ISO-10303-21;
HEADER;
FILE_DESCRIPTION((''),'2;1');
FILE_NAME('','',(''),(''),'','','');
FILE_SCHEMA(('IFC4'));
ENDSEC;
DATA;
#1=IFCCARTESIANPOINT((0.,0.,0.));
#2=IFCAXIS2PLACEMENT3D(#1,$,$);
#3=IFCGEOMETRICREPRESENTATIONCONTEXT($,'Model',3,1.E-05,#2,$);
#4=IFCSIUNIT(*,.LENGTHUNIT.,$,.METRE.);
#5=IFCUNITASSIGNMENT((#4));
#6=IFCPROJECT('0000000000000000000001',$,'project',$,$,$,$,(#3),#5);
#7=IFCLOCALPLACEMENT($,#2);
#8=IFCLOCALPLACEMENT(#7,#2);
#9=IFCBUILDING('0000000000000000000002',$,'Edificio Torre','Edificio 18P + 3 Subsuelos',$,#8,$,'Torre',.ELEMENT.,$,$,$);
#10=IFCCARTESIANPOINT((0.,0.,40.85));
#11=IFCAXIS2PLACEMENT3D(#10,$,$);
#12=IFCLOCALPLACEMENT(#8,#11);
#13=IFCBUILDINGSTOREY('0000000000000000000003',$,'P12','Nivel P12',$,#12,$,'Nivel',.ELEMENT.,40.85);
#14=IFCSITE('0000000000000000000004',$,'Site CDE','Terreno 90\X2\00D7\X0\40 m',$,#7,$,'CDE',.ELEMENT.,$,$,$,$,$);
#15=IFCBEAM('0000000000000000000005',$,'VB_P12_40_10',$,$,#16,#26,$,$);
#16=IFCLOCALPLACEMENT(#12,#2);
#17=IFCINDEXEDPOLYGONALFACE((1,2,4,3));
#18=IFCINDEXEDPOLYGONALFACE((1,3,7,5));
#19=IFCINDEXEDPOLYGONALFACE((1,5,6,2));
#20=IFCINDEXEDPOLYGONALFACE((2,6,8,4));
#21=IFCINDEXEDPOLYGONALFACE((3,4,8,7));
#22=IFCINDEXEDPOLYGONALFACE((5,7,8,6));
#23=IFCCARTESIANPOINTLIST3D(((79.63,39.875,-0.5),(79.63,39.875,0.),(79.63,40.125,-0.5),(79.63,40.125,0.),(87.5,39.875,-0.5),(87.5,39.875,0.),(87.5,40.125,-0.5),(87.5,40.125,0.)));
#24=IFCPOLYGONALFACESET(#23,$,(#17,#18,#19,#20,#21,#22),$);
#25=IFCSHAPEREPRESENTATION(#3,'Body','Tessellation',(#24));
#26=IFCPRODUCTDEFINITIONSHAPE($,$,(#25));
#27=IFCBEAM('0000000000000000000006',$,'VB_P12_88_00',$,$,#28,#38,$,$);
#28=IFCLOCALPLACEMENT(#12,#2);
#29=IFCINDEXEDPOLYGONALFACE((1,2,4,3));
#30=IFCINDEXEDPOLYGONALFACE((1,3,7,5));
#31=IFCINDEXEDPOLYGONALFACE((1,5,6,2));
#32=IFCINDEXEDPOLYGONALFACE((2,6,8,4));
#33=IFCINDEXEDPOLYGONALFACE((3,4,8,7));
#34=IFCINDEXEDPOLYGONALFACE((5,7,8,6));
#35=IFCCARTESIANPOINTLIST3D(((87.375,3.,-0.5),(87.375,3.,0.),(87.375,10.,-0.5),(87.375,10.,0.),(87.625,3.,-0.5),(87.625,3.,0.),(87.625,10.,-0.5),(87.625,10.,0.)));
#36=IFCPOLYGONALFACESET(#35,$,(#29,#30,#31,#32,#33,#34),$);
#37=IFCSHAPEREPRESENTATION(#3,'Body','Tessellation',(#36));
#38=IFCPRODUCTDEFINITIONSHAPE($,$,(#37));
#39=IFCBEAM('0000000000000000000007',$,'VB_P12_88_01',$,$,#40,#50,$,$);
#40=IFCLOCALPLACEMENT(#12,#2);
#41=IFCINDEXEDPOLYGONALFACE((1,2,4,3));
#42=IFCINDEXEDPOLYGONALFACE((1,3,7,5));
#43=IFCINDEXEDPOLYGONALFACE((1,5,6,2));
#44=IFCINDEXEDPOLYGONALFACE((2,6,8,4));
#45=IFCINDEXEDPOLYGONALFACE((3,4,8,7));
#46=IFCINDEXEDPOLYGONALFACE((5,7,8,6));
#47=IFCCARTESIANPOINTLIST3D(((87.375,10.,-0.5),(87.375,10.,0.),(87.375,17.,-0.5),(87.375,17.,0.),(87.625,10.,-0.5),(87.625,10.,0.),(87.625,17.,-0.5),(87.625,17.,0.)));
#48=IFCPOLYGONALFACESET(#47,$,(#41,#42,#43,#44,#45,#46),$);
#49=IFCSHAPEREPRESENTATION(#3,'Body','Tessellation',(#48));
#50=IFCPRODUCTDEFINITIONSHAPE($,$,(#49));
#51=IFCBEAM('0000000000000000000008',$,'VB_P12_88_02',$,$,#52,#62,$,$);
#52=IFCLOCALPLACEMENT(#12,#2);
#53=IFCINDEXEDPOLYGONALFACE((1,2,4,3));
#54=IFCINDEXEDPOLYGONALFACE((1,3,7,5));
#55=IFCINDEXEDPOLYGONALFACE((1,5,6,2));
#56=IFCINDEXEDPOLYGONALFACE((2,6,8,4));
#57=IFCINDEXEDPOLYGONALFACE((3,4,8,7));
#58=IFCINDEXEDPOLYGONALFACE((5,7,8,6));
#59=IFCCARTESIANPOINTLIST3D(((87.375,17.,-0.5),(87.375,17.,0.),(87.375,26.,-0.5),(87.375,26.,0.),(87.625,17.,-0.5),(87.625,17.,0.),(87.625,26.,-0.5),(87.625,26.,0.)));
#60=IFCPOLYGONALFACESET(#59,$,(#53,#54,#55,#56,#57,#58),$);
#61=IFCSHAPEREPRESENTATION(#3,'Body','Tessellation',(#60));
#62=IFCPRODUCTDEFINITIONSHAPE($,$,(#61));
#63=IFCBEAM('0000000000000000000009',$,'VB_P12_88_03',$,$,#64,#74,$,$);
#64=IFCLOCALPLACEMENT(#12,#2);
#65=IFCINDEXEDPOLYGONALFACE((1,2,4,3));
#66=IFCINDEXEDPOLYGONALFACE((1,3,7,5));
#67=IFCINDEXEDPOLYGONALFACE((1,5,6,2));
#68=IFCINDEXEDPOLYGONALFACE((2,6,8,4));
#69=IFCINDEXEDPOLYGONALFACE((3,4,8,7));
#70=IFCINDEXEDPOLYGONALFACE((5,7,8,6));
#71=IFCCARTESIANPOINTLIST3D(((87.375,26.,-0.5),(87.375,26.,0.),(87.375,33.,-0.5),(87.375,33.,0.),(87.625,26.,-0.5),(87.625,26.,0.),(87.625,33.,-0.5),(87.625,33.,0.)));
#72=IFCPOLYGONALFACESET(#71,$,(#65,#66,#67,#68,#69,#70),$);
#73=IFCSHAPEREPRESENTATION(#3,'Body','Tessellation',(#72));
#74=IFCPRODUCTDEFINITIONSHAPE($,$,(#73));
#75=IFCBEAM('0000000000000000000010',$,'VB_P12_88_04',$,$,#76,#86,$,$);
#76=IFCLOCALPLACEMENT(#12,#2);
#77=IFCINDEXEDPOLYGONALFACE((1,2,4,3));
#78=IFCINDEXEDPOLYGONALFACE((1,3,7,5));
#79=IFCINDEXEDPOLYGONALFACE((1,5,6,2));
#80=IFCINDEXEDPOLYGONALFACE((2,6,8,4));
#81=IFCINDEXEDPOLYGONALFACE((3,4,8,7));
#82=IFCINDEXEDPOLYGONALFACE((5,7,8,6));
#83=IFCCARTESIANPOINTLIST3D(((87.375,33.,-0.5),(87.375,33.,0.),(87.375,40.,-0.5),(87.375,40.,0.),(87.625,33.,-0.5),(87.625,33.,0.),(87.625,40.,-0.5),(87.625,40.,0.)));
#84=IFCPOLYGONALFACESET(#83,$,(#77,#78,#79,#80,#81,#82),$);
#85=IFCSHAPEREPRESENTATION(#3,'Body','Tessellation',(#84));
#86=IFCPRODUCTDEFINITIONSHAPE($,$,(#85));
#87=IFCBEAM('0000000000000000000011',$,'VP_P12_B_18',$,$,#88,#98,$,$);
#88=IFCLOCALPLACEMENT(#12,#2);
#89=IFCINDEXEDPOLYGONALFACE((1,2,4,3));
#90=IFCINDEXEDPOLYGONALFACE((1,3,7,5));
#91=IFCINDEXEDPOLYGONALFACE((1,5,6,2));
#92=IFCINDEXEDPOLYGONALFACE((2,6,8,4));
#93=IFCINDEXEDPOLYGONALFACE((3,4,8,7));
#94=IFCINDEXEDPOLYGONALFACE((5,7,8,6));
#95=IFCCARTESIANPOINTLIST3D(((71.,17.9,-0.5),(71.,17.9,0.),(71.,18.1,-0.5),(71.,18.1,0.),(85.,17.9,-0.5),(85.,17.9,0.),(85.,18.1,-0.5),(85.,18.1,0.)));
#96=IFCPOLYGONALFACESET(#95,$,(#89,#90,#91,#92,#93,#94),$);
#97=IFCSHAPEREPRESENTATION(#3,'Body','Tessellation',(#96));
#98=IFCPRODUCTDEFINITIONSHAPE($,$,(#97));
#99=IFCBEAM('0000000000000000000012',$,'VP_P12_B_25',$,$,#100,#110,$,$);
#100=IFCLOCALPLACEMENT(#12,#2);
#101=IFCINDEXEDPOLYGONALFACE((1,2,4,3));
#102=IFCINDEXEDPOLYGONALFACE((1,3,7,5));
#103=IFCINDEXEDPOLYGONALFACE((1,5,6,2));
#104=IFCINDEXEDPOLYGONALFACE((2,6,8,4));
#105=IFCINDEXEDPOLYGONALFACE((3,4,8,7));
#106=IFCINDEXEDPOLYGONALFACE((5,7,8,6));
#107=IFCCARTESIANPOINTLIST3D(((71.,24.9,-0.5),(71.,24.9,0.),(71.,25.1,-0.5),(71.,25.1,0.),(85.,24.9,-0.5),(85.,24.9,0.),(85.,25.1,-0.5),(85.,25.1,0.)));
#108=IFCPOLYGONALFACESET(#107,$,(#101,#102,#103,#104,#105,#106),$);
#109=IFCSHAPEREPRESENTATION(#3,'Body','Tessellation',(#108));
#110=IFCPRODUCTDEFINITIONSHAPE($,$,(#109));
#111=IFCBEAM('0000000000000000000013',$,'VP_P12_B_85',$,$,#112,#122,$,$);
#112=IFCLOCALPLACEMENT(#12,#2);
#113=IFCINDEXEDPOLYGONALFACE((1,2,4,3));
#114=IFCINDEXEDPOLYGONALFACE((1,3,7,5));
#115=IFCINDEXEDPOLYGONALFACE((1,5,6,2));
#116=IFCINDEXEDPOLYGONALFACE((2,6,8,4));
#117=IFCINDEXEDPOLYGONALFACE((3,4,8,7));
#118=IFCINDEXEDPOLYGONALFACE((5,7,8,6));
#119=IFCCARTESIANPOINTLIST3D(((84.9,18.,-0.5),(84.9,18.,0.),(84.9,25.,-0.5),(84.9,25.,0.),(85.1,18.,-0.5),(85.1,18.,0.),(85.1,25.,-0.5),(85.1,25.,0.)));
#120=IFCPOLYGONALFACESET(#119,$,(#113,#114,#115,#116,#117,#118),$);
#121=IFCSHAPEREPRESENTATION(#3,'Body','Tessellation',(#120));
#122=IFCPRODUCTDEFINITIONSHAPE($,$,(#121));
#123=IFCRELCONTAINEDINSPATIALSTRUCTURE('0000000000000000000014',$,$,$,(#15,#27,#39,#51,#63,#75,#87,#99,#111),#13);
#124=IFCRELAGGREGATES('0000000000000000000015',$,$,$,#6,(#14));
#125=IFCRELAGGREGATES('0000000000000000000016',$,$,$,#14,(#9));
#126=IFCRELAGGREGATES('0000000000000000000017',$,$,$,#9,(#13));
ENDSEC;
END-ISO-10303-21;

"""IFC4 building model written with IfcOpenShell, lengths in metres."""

from ifc_helpers import new_model, si_unit, frame, origin, origin_2d, place, context, project, spatial, rectangle, extrude, element, save


model = new_model("IFC4")

# Units and contexts
model_context = context("Model", 3, precision=1e-05, world=origin())
ifc_project = project(units=[si_unit("LENGTHUNIT", "METRE")], contexts=[model_context])

# Site, building, storey
site_placement = place(None, origin())
site = spatial("IfcSite", under=ifc_project, at=site_placement, Name="Site CDE", Description="Terreno 90×40 m", LongName="CDE", CompositionType="ELEMENT")
building_placement = place(site_placement, origin())
building = spatial("IfcBuilding", under=site, at=building_placement, Name="Edificio Torre", Description="Edificio 18P + 3 Subsuelos", LongName="Torre", CompositionType="ELEMENT")
storey_placement = place(building_placement, frame((0.0, 0.0, 40.85)))
storey = spatial("IfcBuildingStorey", under=building, at=storey_placement, Name="P12", Description="Nivel P12", LongName="Nivel", CompositionType="ELEMENT", Elevation=40.85)

# Beams
beam_1_placement = place(storey_placement, frame((83.565, 40.0, -0.5)))
element("IfcBeam", 1, at=beam_1_placement, inside=storey, Name="VB_P12_40_10", context=model_context, shape_type="SweptSolid", body=[
    extrude(rectangle(XDim=7.87, YDim=0.25, at=origin_2d()), origin(), (0.0, 0.0, 1.0), 0.5),
])
for number, where, name in (
    (2, (87.5, 6.5, -0.5), "VB_P12_88_00"),
    (3, (87.5, 13.5, -0.5), "VB_P12_88_01"),
):
    element("IfcBeam", number, at=place(storey_placement, frame(where)), inside=storey, Name=name, context=model_context, shape_type="SweptSolid", body=[
        extrude(rectangle(XDim=0.25, YDim=7.0, at=origin_2d()), origin(), (0.0, 0.0, 1.0), 0.5),
    ])
beam_2_placement = place(storey_placement, frame((87.5, 21.5, -0.5)))
element("IfcBeam", 4, at=beam_2_placement, inside=storey, Name="VB_P12_88_02", context=model_context, shape_type="SweptSolid", body=[
    extrude(rectangle(XDim=0.25, YDim=9.0, at=origin_2d()), origin(), (0.0, 0.0, 1.0), 0.5),
])
for number, where, name in (
    (5, (87.5, 29.5, -0.5), "VB_P12_88_03"),
    (6, (87.5, 36.5, -0.5), "VB_P12_88_04"),
):
    element("IfcBeam", number, at=place(storey_placement, frame(where)), inside=storey, Name=name, context=model_context, shape_type="SweptSolid", body=[
        extrude(rectangle(XDim=0.25, YDim=7.0, at=origin_2d()), origin(), (0.0, 0.0, 1.0), 0.5),
    ])
for number, where, name in (
    (7, (78.0, 18.0, -0.5), "VP_P12_B_18"),
    (8, (78.0, 25.0, -0.5), "VP_P12_B_25"),
):
    element("IfcBeam", number, at=place(storey_placement, frame(where)), inside=storey, Name=name, context=model_context, shape_type="SweptSolid", body=[
        extrude(rectangle(XDim=14.0, YDim=0.2, at=origin_2d()), origin(), (0.0, 0.0, 1.0), 0.5),
    ])
beam_3_placement = place(storey_placement, frame((85.0, 21.5, -0.5)))
element("IfcBeam", 9, at=beam_3_placement, inside=storey, Name="VP_P12_B_85", context=model_context, shape_type="SweptSolid", body=[
    extrude(rectangle(XDim=0.2, YDim=7.0, at=origin_2d()), origin(), (0.0, 0.0, 1.0), 0.5),
])

save(model, "model.ifc")
